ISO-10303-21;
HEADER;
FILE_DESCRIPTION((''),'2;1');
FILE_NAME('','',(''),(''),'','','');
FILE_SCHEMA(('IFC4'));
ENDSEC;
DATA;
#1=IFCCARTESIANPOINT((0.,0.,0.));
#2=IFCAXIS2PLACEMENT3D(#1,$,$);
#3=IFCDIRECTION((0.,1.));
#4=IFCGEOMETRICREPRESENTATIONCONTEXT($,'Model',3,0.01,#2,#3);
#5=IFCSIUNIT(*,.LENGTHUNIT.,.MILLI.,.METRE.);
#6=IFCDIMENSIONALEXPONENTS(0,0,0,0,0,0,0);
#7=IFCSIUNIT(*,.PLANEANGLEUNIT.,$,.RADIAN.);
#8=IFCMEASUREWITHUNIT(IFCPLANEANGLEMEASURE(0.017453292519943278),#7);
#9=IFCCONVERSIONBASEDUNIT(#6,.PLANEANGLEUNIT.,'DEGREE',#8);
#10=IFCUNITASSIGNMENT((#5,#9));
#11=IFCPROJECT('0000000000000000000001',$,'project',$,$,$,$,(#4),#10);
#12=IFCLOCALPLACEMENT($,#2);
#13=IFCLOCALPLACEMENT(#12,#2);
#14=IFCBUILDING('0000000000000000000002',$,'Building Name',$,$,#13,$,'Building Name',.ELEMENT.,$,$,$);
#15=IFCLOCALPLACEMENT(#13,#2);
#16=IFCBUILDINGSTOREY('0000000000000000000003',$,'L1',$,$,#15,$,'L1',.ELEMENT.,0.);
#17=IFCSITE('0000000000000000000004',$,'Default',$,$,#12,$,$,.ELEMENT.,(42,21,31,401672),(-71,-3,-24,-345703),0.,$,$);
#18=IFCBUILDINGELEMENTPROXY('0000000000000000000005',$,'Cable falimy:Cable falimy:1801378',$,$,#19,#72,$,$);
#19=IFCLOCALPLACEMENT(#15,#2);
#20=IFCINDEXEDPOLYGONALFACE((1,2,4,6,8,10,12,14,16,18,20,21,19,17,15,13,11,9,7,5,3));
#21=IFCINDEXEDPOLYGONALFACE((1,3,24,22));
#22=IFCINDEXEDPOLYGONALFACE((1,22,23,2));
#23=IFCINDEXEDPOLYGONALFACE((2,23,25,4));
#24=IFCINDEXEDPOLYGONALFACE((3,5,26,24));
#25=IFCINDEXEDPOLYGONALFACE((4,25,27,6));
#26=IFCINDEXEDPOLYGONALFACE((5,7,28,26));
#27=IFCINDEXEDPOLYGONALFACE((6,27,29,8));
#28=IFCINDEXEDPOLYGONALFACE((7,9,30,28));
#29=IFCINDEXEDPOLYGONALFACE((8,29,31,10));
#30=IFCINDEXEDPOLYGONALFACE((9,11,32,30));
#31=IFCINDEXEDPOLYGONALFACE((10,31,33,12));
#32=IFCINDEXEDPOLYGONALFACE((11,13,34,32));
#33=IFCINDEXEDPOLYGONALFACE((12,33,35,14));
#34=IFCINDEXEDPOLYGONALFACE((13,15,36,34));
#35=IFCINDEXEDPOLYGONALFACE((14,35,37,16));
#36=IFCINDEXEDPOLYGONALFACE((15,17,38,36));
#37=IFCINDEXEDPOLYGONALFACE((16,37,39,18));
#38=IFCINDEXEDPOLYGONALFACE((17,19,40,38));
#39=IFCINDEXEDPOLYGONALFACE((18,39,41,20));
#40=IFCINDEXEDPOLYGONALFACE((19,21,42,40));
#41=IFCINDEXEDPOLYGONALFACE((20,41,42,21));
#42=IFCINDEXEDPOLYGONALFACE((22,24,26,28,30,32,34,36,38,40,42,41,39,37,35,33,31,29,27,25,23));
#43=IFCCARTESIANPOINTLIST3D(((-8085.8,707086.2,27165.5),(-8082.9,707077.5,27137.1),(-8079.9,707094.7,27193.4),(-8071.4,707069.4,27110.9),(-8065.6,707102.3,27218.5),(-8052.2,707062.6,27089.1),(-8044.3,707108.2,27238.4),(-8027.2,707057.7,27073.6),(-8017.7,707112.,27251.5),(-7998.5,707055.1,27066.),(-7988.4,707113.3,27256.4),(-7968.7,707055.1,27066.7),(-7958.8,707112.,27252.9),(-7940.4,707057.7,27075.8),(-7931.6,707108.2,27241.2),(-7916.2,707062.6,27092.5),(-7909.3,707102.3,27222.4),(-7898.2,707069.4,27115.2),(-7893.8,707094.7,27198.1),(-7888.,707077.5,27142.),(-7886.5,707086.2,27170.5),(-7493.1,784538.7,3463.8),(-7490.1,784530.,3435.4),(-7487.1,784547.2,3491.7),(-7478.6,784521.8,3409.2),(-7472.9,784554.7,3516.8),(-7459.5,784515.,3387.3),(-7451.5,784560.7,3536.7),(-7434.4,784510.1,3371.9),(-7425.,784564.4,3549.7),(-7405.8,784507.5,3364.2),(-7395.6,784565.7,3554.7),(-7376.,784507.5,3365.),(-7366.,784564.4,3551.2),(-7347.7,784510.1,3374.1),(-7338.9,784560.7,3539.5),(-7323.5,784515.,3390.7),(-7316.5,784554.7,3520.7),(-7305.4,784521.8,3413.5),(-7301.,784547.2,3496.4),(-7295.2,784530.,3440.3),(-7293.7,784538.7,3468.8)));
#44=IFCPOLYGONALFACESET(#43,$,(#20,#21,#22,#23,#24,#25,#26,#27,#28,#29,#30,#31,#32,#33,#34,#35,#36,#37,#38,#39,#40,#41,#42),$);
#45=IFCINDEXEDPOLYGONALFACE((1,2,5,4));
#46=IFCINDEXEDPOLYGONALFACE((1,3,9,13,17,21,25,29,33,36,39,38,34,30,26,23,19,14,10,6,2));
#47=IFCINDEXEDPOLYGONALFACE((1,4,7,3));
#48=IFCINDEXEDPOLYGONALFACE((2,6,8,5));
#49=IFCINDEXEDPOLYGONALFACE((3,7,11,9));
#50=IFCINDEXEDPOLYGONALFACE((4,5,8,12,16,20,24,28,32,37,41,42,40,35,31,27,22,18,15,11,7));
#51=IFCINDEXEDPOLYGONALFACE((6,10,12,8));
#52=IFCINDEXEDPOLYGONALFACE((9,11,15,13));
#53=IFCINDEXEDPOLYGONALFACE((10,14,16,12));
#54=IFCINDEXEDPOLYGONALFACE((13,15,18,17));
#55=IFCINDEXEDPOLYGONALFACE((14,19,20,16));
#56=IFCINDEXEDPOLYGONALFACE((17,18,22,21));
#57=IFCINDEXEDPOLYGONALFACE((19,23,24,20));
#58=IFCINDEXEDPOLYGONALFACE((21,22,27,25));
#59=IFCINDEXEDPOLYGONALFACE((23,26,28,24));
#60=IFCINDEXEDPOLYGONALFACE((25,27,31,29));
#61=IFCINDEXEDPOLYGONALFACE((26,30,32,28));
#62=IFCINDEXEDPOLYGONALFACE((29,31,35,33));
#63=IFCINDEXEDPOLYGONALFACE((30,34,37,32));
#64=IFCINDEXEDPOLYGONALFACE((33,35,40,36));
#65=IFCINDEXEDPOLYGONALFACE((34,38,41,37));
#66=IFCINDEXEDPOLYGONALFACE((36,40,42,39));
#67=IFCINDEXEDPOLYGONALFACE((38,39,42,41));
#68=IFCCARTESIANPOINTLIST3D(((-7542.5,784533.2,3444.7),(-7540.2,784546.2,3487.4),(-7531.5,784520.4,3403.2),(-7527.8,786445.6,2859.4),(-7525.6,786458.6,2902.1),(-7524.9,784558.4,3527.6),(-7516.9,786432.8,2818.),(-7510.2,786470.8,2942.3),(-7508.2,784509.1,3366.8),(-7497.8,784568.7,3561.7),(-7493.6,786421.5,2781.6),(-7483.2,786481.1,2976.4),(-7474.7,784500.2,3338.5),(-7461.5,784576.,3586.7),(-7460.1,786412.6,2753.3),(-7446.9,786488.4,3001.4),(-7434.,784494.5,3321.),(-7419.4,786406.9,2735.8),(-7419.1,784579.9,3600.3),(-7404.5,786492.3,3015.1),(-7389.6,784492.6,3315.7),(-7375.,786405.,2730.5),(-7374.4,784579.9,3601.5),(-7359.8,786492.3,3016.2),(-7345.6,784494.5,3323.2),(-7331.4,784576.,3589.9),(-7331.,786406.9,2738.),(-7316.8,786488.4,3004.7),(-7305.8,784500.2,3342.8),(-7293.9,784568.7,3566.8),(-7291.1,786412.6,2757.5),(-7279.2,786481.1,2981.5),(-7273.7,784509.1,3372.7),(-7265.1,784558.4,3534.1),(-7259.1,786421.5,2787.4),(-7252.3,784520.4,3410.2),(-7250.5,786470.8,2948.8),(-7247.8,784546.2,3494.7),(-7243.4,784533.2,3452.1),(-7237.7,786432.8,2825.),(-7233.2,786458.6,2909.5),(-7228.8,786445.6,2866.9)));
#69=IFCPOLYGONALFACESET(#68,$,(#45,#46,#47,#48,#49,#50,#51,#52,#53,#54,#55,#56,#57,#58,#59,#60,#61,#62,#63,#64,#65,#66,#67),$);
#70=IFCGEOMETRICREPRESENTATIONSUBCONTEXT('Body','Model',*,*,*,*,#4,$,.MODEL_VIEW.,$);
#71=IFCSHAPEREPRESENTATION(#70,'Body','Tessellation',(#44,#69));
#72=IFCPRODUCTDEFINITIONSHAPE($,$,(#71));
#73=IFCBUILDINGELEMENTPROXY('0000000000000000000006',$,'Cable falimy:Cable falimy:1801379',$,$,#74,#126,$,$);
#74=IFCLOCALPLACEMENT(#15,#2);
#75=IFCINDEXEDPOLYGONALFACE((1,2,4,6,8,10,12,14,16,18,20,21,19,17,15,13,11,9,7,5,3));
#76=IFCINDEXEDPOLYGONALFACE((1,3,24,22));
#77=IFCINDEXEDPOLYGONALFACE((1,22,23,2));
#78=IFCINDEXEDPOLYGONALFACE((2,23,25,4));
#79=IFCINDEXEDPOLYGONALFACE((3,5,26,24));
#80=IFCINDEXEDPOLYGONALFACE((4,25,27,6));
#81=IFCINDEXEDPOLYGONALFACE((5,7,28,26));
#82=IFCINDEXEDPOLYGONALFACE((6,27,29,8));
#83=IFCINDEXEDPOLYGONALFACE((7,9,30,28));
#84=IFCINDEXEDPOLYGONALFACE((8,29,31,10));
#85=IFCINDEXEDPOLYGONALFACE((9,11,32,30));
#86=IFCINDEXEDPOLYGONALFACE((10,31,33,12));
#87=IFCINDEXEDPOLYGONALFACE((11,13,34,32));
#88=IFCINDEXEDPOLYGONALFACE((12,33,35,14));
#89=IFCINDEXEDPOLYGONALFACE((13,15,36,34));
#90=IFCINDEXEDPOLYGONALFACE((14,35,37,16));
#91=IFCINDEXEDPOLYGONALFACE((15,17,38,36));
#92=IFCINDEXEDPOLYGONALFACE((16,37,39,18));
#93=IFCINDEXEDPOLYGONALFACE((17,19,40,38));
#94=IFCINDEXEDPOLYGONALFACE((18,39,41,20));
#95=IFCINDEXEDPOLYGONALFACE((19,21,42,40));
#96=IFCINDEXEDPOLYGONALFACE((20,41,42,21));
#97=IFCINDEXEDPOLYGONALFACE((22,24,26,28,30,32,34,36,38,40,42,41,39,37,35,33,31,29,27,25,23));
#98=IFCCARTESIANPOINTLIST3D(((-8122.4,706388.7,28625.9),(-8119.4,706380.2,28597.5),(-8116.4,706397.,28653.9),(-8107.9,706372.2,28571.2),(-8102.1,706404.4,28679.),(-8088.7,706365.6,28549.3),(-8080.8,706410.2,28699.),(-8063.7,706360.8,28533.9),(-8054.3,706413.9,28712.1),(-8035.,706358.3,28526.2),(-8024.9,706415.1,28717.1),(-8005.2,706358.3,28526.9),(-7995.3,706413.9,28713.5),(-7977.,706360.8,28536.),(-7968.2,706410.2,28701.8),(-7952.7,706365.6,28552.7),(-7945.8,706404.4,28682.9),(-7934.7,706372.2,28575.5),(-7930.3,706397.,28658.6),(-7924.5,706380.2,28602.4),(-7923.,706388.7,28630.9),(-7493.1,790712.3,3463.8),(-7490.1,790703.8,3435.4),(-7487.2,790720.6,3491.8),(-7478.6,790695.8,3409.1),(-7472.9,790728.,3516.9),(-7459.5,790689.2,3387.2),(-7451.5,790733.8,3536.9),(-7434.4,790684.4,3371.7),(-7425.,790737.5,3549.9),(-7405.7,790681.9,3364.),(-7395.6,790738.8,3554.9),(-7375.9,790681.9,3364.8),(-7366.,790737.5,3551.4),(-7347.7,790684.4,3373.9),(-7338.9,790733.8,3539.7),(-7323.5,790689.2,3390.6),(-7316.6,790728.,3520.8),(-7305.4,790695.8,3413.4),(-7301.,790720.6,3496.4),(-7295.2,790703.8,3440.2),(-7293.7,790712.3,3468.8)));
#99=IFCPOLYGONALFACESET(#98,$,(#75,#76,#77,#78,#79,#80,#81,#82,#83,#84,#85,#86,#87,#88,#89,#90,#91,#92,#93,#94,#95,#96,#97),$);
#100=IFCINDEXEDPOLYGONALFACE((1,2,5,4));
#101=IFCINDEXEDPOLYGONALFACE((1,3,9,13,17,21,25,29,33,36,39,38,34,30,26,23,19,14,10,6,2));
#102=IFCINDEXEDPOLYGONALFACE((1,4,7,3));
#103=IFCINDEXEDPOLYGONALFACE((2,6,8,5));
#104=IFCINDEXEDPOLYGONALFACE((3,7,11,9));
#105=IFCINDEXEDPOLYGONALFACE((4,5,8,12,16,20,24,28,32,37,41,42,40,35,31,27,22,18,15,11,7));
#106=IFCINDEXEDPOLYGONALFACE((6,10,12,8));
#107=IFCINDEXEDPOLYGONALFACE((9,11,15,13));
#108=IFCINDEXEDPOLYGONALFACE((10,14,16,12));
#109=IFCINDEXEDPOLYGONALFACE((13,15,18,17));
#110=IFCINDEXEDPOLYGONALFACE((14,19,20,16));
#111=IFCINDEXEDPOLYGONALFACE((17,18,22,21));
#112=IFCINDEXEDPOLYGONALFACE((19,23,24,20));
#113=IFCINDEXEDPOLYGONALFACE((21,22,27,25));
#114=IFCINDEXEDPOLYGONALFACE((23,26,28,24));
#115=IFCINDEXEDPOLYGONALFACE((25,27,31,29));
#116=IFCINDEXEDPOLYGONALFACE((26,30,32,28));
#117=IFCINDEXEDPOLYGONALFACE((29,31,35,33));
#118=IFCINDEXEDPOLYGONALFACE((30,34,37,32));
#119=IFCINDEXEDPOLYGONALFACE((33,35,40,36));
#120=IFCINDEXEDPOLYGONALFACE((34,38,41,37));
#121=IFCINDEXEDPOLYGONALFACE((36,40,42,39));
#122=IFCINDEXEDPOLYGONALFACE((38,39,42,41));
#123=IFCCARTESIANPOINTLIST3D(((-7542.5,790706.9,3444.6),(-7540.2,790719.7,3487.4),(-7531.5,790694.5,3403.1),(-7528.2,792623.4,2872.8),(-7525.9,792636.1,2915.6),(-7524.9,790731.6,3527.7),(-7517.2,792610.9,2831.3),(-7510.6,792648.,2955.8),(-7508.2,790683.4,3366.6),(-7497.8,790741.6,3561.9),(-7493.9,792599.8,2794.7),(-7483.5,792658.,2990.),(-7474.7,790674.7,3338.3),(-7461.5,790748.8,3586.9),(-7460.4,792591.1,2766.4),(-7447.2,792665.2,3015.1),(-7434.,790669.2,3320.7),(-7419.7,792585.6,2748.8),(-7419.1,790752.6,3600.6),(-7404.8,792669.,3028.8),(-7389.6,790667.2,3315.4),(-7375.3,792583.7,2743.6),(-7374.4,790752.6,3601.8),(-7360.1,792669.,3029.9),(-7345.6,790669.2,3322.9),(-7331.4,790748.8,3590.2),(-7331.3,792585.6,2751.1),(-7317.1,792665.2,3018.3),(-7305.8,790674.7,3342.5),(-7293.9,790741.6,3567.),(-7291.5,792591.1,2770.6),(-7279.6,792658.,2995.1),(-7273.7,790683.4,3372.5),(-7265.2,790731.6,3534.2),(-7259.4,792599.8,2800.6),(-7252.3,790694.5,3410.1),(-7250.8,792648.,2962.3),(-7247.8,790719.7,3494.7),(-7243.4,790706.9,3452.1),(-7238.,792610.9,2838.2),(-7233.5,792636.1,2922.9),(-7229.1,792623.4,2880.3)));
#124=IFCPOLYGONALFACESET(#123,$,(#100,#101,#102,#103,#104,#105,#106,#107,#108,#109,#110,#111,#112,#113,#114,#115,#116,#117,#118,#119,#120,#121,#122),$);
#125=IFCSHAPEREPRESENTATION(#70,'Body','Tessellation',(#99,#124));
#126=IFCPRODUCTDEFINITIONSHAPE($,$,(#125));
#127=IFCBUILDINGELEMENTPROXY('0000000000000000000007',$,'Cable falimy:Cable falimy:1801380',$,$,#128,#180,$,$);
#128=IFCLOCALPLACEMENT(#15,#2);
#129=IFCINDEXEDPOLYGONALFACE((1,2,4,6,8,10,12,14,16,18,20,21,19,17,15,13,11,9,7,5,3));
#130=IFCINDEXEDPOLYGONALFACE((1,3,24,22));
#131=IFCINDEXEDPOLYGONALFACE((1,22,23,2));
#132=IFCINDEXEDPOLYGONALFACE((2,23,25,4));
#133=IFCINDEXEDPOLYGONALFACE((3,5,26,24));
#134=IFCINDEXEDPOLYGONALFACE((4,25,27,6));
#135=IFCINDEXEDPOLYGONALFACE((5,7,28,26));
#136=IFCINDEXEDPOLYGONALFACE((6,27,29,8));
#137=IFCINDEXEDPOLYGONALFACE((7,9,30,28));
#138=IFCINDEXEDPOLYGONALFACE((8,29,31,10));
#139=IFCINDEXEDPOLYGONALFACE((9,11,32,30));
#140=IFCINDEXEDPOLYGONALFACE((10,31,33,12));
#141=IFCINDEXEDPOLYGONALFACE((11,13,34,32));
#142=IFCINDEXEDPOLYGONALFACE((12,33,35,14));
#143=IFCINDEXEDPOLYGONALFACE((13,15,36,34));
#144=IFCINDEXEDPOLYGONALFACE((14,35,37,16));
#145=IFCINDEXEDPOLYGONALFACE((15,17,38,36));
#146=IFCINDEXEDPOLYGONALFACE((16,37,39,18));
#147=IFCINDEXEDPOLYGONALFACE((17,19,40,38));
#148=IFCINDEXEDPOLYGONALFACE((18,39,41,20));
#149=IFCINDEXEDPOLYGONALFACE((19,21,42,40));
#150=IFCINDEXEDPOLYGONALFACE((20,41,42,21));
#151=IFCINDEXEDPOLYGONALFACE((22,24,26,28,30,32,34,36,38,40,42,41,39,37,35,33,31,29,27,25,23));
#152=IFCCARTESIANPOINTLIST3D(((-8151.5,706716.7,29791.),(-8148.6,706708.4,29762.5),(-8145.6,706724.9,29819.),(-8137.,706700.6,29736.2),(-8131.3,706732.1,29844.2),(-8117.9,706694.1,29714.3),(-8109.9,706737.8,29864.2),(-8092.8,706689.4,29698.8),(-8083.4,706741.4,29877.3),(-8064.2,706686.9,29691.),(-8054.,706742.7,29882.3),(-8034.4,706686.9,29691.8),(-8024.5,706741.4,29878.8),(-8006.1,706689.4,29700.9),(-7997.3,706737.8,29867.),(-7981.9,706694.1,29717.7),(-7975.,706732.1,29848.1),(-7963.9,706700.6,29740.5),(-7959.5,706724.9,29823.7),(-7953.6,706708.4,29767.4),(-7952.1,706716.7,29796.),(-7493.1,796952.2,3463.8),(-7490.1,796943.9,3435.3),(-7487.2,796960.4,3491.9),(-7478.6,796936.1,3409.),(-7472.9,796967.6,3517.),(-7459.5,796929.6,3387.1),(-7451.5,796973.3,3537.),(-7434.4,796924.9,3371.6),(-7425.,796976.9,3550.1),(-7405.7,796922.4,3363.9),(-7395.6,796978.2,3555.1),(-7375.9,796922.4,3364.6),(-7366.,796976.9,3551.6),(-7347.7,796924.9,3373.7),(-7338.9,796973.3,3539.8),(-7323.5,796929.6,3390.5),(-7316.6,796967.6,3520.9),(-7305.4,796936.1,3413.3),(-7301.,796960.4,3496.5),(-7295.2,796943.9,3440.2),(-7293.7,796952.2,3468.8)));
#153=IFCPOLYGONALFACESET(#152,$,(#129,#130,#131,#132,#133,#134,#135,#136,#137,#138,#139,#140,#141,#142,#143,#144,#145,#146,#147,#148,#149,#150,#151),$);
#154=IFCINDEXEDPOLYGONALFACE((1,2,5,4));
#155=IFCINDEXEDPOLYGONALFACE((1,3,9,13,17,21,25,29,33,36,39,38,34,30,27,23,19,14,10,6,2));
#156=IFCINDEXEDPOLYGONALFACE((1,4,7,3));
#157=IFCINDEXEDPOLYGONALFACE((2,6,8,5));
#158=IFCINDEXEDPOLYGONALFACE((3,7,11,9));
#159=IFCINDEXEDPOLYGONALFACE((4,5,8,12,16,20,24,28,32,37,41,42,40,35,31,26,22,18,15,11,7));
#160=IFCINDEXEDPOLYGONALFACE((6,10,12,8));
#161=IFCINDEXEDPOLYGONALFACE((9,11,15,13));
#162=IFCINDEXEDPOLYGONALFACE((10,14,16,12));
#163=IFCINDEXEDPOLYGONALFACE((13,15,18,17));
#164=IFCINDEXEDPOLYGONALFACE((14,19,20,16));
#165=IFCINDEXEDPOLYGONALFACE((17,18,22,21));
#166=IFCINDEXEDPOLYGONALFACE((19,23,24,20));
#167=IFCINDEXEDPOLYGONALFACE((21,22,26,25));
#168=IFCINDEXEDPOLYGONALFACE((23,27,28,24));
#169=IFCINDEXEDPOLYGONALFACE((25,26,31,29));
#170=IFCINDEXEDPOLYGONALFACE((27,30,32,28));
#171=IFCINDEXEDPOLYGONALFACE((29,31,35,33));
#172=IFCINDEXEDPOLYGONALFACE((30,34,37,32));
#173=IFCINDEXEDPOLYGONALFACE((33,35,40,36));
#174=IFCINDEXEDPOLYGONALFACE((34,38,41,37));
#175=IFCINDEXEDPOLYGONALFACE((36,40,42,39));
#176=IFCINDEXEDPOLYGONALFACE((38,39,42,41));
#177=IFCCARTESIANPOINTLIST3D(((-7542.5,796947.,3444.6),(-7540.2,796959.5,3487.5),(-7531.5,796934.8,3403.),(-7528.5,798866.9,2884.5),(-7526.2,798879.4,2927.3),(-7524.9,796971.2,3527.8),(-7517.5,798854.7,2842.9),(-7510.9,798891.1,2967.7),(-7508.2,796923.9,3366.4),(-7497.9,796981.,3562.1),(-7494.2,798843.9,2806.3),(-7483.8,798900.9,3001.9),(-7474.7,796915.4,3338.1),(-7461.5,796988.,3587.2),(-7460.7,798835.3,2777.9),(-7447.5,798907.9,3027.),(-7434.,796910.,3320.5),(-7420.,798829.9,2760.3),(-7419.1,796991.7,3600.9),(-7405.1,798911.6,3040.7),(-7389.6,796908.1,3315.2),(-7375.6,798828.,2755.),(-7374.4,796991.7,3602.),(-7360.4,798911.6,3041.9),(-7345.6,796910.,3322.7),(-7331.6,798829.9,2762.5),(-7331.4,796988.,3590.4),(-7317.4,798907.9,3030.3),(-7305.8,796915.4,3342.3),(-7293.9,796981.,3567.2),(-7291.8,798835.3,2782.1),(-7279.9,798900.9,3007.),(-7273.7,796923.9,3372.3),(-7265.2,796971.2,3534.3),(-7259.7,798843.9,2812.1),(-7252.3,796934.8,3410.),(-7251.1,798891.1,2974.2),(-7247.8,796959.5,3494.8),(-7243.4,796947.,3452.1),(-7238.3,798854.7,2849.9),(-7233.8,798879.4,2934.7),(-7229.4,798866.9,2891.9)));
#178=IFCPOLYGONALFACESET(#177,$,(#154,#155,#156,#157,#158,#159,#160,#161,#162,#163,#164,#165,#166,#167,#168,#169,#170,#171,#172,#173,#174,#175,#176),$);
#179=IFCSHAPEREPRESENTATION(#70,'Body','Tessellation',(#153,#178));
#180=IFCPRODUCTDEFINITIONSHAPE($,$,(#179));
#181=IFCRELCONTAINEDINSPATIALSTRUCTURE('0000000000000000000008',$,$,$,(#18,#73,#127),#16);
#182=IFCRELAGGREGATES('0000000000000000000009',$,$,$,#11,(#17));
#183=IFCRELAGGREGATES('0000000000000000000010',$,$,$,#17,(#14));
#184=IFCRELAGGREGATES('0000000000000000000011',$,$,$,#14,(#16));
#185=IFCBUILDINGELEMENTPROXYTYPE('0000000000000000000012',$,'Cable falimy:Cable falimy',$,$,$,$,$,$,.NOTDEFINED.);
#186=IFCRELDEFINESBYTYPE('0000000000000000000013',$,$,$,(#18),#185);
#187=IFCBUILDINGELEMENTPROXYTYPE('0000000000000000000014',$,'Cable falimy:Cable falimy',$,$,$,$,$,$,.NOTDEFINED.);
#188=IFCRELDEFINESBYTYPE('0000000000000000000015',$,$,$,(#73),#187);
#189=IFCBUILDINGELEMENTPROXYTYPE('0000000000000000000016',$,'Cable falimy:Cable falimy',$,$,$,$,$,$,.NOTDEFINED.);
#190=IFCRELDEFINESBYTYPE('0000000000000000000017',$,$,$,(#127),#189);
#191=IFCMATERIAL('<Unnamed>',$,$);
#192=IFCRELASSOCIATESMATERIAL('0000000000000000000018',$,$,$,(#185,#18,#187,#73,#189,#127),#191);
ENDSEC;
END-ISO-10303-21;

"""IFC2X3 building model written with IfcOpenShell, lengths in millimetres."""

from ifc_helpers import new_model, entity, si_unit, converted_unit, direction, frame, frame_2d, origin, place, context, subcontext, project, spatial, circle, extrude, source, transform, mapped, material, type_object, type_shapes, element, save


model = new_model("IFC2X3")

# Units and contexts
model_context = context("Model", 3, precision=0.01, world=origin(), true_north=direction((0.0, 1.0)))
body_context = subcontext(model_context, "Body", "Model", "MODEL_VIEW")
ifc_project = project(units=[si_unit("LENGTHUNIT", "METRE", prefix="MILLI"), converted_unit("PLANEANGLEUNIT", "DEGREE", entity("IfcPlaneAngleMeasure", 0.017453292519943278), si_unit("PLANEANGLEUNIT", "RADIAN"), dimensions=[0, 0, 0, 0, 0, 0, 0])], contexts=[model_context])

# Site, building, storey
site_placement = place(None, origin())
site = spatial("IfcSite", under=ifc_project, at=site_placement, Name="Default", CompositionType="ELEMENT", RefLatitude=(42, 21, 31, 401672), RefLongitude=(-71, -3, -24, -345703), RefElevation=0.0)
building_placement = place(site_placement, origin())
building = spatial("IfcBuilding", under=site, at=building_placement, Name="Building Name", LongName="Building Name", CompositionType="ELEMENT")
storey_placement = place(building_placement, origin())
storey = spatial("IfcBuildingStorey", under=building, at=storey_placement, Name="L1", LongName="L1", CompositionType="ELEMENT", Elevation=0.0)

# Shared definitions
ifc_material = material(Name="<Unnamed>")

# Building element proxies
building_element_proxy_type_1 = type_object("IfcBuildingElementProxyType", Name="Cable falimy:Cable falimy", PredefinedType="NOTDEFINED", material=ifc_material)
shared_shape_1 = source(origin(), body_context, "Body", "SweptSolid", [
    extrude(circle(Radius=100.0, at=frame_2d((0.0, 0.0), x_axis=(1.0, 0.0))), frame((0.0, 0.0, 0.0), z_axis=(0.956203, 0.0, 0.292706), x_axis=(-0.292706, 0.0, 0.956203)), (0.0, 0.0, 1.0), 81000.0),
    extrude(circle(Radius=150.0, at=frame_2d((0.0, 0.0), x_axis=(1.0, 0.0))), frame((-1912.4, 0.0, -585.4), z_axis=(0.956203, 0.0, 0.292706), x_axis=(0.292706, 0.0, -0.956203)), (0.0, 0.0, 1.0), 2000.0),
])
type_shapes(building_element_proxy_type_1, [shared_shape_1])
proxy_1_placement = place(storey_placement, frame((-7393.2, 784536.5, 3459.1), z_axis=(-0.025001, 0.0, 0.999687), x_axis=(0.0, -1.0, 0.0)))
element("IfcBuildingElementProxy", 1, at=proxy_1_placement, inside=storey, type_object=building_element_proxy_type_1, material=ifc_material, Name="Cable falimy:Cable falimy:1801378", context=body_context, shape_type="MappedRepresentation", body=[
    mapped(shared_shape_1, transform((0.0, 0.0, 0.0), scale=1.0)),
])
building_element_proxy_type_2 = type_object("IfcBuildingElementProxyType", Name="Cable falimy:Cable falimy", PredefinedType="NOTDEFINED", material=ifc_material)
shared_shape_2 = source(origin(), body_context, "Body", "SweptSolid", [
    extrude(circle(Radius=100.0, at=frame_2d((0.0, 0.0), x_axis=(1.0, 0.0))), frame((0.0, 0.0, 0.0), z_axis=(0.958223, 0.0, 0.286023), x_axis=(-0.286023, 0.0, 0.958223)), (0.0, 0.0, 1.0), 88000.0),
    extrude(circle(Radius=150.0, at=frame_2d((0.0, 0.0), x_axis=(1.0, 0.0))), frame((-1916.4, 0.0, -572.0), z_axis=(0.958223, 0.0, 0.286023), x_axis=(0.286023, 0.0, -0.958223)), (0.0, 0.0, 1.0), 2000.0),
])
type_shapes(building_element_proxy_type_2, [shared_shape_2])
proxy_2_placement = place(storey_placement, frame((-7393.2, 790710.1, 3459.1), z_axis=(-0.025001, 0.0, 0.999687), x_axis=(0.0, -1.0, 0.0)))
element("IfcBuildingElementProxy", 2, at=proxy_2_placement, inside=storey, type_object=building_element_proxy_type_2, material=ifc_material, Name="Cable falimy:Cable falimy:1801379", context=body_context, shape_type="MappedRepresentation", body=[
    mapped(shared_shape_2, transform((0.0, 0.0, 0.0), scale=1.0)),
])
building_element_proxy_type_3 = type_object("IfcBuildingElementProxyType", Name="Cable falimy:Cable falimy", PredefinedType="NOTDEFINED", material=ifc_material)
shared_shape_3 = source(origin(), body_context, "Body", "SweptSolid", [
    extrude(circle(Radius=100.0, at=frame_2d((0.0, 0.0), x_axis=(1.0, 0.0))), frame((0.0, 0.0, 0.0), z_axis=(0.959952, 0.0, 0.280164), x_axis=(-0.280164, 0.0, 0.959952)), (0.0, 0.0, 1.0), 94000.0),
    extrude(circle(Radius=150.0, at=frame_2d((0.0, 0.0), x_axis=(1.0, 0.0))), frame((-1919.9, 0.0, -560.3), z_axis=(0.959952, 0.0, 0.280164), x_axis=(0.280164, 0.0, -0.959952)), (0.0, 0.0, 1.0), 2000.0),
])
type_shapes(building_element_proxy_type_3, [shared_shape_3])
proxy_3_placement = place(storey_placement, frame((-7393.2, 796950.1, 3459.1), z_axis=(-0.025001, 0.0, 0.999687), x_axis=(0.0, -1.0, 0.0)))
element("IfcBuildingElementProxy", 3, at=proxy_3_placement, inside=storey, type_object=building_element_proxy_type_3, material=ifc_material, Name="Cable falimy:Cable falimy:1801380", context=body_context, shape_type="MappedRepresentation", body=[
    mapped(shared_shape_3, transform((0.0, 0.0, 0.0), scale=1.0)),
])

save(model, "model.ifc")
